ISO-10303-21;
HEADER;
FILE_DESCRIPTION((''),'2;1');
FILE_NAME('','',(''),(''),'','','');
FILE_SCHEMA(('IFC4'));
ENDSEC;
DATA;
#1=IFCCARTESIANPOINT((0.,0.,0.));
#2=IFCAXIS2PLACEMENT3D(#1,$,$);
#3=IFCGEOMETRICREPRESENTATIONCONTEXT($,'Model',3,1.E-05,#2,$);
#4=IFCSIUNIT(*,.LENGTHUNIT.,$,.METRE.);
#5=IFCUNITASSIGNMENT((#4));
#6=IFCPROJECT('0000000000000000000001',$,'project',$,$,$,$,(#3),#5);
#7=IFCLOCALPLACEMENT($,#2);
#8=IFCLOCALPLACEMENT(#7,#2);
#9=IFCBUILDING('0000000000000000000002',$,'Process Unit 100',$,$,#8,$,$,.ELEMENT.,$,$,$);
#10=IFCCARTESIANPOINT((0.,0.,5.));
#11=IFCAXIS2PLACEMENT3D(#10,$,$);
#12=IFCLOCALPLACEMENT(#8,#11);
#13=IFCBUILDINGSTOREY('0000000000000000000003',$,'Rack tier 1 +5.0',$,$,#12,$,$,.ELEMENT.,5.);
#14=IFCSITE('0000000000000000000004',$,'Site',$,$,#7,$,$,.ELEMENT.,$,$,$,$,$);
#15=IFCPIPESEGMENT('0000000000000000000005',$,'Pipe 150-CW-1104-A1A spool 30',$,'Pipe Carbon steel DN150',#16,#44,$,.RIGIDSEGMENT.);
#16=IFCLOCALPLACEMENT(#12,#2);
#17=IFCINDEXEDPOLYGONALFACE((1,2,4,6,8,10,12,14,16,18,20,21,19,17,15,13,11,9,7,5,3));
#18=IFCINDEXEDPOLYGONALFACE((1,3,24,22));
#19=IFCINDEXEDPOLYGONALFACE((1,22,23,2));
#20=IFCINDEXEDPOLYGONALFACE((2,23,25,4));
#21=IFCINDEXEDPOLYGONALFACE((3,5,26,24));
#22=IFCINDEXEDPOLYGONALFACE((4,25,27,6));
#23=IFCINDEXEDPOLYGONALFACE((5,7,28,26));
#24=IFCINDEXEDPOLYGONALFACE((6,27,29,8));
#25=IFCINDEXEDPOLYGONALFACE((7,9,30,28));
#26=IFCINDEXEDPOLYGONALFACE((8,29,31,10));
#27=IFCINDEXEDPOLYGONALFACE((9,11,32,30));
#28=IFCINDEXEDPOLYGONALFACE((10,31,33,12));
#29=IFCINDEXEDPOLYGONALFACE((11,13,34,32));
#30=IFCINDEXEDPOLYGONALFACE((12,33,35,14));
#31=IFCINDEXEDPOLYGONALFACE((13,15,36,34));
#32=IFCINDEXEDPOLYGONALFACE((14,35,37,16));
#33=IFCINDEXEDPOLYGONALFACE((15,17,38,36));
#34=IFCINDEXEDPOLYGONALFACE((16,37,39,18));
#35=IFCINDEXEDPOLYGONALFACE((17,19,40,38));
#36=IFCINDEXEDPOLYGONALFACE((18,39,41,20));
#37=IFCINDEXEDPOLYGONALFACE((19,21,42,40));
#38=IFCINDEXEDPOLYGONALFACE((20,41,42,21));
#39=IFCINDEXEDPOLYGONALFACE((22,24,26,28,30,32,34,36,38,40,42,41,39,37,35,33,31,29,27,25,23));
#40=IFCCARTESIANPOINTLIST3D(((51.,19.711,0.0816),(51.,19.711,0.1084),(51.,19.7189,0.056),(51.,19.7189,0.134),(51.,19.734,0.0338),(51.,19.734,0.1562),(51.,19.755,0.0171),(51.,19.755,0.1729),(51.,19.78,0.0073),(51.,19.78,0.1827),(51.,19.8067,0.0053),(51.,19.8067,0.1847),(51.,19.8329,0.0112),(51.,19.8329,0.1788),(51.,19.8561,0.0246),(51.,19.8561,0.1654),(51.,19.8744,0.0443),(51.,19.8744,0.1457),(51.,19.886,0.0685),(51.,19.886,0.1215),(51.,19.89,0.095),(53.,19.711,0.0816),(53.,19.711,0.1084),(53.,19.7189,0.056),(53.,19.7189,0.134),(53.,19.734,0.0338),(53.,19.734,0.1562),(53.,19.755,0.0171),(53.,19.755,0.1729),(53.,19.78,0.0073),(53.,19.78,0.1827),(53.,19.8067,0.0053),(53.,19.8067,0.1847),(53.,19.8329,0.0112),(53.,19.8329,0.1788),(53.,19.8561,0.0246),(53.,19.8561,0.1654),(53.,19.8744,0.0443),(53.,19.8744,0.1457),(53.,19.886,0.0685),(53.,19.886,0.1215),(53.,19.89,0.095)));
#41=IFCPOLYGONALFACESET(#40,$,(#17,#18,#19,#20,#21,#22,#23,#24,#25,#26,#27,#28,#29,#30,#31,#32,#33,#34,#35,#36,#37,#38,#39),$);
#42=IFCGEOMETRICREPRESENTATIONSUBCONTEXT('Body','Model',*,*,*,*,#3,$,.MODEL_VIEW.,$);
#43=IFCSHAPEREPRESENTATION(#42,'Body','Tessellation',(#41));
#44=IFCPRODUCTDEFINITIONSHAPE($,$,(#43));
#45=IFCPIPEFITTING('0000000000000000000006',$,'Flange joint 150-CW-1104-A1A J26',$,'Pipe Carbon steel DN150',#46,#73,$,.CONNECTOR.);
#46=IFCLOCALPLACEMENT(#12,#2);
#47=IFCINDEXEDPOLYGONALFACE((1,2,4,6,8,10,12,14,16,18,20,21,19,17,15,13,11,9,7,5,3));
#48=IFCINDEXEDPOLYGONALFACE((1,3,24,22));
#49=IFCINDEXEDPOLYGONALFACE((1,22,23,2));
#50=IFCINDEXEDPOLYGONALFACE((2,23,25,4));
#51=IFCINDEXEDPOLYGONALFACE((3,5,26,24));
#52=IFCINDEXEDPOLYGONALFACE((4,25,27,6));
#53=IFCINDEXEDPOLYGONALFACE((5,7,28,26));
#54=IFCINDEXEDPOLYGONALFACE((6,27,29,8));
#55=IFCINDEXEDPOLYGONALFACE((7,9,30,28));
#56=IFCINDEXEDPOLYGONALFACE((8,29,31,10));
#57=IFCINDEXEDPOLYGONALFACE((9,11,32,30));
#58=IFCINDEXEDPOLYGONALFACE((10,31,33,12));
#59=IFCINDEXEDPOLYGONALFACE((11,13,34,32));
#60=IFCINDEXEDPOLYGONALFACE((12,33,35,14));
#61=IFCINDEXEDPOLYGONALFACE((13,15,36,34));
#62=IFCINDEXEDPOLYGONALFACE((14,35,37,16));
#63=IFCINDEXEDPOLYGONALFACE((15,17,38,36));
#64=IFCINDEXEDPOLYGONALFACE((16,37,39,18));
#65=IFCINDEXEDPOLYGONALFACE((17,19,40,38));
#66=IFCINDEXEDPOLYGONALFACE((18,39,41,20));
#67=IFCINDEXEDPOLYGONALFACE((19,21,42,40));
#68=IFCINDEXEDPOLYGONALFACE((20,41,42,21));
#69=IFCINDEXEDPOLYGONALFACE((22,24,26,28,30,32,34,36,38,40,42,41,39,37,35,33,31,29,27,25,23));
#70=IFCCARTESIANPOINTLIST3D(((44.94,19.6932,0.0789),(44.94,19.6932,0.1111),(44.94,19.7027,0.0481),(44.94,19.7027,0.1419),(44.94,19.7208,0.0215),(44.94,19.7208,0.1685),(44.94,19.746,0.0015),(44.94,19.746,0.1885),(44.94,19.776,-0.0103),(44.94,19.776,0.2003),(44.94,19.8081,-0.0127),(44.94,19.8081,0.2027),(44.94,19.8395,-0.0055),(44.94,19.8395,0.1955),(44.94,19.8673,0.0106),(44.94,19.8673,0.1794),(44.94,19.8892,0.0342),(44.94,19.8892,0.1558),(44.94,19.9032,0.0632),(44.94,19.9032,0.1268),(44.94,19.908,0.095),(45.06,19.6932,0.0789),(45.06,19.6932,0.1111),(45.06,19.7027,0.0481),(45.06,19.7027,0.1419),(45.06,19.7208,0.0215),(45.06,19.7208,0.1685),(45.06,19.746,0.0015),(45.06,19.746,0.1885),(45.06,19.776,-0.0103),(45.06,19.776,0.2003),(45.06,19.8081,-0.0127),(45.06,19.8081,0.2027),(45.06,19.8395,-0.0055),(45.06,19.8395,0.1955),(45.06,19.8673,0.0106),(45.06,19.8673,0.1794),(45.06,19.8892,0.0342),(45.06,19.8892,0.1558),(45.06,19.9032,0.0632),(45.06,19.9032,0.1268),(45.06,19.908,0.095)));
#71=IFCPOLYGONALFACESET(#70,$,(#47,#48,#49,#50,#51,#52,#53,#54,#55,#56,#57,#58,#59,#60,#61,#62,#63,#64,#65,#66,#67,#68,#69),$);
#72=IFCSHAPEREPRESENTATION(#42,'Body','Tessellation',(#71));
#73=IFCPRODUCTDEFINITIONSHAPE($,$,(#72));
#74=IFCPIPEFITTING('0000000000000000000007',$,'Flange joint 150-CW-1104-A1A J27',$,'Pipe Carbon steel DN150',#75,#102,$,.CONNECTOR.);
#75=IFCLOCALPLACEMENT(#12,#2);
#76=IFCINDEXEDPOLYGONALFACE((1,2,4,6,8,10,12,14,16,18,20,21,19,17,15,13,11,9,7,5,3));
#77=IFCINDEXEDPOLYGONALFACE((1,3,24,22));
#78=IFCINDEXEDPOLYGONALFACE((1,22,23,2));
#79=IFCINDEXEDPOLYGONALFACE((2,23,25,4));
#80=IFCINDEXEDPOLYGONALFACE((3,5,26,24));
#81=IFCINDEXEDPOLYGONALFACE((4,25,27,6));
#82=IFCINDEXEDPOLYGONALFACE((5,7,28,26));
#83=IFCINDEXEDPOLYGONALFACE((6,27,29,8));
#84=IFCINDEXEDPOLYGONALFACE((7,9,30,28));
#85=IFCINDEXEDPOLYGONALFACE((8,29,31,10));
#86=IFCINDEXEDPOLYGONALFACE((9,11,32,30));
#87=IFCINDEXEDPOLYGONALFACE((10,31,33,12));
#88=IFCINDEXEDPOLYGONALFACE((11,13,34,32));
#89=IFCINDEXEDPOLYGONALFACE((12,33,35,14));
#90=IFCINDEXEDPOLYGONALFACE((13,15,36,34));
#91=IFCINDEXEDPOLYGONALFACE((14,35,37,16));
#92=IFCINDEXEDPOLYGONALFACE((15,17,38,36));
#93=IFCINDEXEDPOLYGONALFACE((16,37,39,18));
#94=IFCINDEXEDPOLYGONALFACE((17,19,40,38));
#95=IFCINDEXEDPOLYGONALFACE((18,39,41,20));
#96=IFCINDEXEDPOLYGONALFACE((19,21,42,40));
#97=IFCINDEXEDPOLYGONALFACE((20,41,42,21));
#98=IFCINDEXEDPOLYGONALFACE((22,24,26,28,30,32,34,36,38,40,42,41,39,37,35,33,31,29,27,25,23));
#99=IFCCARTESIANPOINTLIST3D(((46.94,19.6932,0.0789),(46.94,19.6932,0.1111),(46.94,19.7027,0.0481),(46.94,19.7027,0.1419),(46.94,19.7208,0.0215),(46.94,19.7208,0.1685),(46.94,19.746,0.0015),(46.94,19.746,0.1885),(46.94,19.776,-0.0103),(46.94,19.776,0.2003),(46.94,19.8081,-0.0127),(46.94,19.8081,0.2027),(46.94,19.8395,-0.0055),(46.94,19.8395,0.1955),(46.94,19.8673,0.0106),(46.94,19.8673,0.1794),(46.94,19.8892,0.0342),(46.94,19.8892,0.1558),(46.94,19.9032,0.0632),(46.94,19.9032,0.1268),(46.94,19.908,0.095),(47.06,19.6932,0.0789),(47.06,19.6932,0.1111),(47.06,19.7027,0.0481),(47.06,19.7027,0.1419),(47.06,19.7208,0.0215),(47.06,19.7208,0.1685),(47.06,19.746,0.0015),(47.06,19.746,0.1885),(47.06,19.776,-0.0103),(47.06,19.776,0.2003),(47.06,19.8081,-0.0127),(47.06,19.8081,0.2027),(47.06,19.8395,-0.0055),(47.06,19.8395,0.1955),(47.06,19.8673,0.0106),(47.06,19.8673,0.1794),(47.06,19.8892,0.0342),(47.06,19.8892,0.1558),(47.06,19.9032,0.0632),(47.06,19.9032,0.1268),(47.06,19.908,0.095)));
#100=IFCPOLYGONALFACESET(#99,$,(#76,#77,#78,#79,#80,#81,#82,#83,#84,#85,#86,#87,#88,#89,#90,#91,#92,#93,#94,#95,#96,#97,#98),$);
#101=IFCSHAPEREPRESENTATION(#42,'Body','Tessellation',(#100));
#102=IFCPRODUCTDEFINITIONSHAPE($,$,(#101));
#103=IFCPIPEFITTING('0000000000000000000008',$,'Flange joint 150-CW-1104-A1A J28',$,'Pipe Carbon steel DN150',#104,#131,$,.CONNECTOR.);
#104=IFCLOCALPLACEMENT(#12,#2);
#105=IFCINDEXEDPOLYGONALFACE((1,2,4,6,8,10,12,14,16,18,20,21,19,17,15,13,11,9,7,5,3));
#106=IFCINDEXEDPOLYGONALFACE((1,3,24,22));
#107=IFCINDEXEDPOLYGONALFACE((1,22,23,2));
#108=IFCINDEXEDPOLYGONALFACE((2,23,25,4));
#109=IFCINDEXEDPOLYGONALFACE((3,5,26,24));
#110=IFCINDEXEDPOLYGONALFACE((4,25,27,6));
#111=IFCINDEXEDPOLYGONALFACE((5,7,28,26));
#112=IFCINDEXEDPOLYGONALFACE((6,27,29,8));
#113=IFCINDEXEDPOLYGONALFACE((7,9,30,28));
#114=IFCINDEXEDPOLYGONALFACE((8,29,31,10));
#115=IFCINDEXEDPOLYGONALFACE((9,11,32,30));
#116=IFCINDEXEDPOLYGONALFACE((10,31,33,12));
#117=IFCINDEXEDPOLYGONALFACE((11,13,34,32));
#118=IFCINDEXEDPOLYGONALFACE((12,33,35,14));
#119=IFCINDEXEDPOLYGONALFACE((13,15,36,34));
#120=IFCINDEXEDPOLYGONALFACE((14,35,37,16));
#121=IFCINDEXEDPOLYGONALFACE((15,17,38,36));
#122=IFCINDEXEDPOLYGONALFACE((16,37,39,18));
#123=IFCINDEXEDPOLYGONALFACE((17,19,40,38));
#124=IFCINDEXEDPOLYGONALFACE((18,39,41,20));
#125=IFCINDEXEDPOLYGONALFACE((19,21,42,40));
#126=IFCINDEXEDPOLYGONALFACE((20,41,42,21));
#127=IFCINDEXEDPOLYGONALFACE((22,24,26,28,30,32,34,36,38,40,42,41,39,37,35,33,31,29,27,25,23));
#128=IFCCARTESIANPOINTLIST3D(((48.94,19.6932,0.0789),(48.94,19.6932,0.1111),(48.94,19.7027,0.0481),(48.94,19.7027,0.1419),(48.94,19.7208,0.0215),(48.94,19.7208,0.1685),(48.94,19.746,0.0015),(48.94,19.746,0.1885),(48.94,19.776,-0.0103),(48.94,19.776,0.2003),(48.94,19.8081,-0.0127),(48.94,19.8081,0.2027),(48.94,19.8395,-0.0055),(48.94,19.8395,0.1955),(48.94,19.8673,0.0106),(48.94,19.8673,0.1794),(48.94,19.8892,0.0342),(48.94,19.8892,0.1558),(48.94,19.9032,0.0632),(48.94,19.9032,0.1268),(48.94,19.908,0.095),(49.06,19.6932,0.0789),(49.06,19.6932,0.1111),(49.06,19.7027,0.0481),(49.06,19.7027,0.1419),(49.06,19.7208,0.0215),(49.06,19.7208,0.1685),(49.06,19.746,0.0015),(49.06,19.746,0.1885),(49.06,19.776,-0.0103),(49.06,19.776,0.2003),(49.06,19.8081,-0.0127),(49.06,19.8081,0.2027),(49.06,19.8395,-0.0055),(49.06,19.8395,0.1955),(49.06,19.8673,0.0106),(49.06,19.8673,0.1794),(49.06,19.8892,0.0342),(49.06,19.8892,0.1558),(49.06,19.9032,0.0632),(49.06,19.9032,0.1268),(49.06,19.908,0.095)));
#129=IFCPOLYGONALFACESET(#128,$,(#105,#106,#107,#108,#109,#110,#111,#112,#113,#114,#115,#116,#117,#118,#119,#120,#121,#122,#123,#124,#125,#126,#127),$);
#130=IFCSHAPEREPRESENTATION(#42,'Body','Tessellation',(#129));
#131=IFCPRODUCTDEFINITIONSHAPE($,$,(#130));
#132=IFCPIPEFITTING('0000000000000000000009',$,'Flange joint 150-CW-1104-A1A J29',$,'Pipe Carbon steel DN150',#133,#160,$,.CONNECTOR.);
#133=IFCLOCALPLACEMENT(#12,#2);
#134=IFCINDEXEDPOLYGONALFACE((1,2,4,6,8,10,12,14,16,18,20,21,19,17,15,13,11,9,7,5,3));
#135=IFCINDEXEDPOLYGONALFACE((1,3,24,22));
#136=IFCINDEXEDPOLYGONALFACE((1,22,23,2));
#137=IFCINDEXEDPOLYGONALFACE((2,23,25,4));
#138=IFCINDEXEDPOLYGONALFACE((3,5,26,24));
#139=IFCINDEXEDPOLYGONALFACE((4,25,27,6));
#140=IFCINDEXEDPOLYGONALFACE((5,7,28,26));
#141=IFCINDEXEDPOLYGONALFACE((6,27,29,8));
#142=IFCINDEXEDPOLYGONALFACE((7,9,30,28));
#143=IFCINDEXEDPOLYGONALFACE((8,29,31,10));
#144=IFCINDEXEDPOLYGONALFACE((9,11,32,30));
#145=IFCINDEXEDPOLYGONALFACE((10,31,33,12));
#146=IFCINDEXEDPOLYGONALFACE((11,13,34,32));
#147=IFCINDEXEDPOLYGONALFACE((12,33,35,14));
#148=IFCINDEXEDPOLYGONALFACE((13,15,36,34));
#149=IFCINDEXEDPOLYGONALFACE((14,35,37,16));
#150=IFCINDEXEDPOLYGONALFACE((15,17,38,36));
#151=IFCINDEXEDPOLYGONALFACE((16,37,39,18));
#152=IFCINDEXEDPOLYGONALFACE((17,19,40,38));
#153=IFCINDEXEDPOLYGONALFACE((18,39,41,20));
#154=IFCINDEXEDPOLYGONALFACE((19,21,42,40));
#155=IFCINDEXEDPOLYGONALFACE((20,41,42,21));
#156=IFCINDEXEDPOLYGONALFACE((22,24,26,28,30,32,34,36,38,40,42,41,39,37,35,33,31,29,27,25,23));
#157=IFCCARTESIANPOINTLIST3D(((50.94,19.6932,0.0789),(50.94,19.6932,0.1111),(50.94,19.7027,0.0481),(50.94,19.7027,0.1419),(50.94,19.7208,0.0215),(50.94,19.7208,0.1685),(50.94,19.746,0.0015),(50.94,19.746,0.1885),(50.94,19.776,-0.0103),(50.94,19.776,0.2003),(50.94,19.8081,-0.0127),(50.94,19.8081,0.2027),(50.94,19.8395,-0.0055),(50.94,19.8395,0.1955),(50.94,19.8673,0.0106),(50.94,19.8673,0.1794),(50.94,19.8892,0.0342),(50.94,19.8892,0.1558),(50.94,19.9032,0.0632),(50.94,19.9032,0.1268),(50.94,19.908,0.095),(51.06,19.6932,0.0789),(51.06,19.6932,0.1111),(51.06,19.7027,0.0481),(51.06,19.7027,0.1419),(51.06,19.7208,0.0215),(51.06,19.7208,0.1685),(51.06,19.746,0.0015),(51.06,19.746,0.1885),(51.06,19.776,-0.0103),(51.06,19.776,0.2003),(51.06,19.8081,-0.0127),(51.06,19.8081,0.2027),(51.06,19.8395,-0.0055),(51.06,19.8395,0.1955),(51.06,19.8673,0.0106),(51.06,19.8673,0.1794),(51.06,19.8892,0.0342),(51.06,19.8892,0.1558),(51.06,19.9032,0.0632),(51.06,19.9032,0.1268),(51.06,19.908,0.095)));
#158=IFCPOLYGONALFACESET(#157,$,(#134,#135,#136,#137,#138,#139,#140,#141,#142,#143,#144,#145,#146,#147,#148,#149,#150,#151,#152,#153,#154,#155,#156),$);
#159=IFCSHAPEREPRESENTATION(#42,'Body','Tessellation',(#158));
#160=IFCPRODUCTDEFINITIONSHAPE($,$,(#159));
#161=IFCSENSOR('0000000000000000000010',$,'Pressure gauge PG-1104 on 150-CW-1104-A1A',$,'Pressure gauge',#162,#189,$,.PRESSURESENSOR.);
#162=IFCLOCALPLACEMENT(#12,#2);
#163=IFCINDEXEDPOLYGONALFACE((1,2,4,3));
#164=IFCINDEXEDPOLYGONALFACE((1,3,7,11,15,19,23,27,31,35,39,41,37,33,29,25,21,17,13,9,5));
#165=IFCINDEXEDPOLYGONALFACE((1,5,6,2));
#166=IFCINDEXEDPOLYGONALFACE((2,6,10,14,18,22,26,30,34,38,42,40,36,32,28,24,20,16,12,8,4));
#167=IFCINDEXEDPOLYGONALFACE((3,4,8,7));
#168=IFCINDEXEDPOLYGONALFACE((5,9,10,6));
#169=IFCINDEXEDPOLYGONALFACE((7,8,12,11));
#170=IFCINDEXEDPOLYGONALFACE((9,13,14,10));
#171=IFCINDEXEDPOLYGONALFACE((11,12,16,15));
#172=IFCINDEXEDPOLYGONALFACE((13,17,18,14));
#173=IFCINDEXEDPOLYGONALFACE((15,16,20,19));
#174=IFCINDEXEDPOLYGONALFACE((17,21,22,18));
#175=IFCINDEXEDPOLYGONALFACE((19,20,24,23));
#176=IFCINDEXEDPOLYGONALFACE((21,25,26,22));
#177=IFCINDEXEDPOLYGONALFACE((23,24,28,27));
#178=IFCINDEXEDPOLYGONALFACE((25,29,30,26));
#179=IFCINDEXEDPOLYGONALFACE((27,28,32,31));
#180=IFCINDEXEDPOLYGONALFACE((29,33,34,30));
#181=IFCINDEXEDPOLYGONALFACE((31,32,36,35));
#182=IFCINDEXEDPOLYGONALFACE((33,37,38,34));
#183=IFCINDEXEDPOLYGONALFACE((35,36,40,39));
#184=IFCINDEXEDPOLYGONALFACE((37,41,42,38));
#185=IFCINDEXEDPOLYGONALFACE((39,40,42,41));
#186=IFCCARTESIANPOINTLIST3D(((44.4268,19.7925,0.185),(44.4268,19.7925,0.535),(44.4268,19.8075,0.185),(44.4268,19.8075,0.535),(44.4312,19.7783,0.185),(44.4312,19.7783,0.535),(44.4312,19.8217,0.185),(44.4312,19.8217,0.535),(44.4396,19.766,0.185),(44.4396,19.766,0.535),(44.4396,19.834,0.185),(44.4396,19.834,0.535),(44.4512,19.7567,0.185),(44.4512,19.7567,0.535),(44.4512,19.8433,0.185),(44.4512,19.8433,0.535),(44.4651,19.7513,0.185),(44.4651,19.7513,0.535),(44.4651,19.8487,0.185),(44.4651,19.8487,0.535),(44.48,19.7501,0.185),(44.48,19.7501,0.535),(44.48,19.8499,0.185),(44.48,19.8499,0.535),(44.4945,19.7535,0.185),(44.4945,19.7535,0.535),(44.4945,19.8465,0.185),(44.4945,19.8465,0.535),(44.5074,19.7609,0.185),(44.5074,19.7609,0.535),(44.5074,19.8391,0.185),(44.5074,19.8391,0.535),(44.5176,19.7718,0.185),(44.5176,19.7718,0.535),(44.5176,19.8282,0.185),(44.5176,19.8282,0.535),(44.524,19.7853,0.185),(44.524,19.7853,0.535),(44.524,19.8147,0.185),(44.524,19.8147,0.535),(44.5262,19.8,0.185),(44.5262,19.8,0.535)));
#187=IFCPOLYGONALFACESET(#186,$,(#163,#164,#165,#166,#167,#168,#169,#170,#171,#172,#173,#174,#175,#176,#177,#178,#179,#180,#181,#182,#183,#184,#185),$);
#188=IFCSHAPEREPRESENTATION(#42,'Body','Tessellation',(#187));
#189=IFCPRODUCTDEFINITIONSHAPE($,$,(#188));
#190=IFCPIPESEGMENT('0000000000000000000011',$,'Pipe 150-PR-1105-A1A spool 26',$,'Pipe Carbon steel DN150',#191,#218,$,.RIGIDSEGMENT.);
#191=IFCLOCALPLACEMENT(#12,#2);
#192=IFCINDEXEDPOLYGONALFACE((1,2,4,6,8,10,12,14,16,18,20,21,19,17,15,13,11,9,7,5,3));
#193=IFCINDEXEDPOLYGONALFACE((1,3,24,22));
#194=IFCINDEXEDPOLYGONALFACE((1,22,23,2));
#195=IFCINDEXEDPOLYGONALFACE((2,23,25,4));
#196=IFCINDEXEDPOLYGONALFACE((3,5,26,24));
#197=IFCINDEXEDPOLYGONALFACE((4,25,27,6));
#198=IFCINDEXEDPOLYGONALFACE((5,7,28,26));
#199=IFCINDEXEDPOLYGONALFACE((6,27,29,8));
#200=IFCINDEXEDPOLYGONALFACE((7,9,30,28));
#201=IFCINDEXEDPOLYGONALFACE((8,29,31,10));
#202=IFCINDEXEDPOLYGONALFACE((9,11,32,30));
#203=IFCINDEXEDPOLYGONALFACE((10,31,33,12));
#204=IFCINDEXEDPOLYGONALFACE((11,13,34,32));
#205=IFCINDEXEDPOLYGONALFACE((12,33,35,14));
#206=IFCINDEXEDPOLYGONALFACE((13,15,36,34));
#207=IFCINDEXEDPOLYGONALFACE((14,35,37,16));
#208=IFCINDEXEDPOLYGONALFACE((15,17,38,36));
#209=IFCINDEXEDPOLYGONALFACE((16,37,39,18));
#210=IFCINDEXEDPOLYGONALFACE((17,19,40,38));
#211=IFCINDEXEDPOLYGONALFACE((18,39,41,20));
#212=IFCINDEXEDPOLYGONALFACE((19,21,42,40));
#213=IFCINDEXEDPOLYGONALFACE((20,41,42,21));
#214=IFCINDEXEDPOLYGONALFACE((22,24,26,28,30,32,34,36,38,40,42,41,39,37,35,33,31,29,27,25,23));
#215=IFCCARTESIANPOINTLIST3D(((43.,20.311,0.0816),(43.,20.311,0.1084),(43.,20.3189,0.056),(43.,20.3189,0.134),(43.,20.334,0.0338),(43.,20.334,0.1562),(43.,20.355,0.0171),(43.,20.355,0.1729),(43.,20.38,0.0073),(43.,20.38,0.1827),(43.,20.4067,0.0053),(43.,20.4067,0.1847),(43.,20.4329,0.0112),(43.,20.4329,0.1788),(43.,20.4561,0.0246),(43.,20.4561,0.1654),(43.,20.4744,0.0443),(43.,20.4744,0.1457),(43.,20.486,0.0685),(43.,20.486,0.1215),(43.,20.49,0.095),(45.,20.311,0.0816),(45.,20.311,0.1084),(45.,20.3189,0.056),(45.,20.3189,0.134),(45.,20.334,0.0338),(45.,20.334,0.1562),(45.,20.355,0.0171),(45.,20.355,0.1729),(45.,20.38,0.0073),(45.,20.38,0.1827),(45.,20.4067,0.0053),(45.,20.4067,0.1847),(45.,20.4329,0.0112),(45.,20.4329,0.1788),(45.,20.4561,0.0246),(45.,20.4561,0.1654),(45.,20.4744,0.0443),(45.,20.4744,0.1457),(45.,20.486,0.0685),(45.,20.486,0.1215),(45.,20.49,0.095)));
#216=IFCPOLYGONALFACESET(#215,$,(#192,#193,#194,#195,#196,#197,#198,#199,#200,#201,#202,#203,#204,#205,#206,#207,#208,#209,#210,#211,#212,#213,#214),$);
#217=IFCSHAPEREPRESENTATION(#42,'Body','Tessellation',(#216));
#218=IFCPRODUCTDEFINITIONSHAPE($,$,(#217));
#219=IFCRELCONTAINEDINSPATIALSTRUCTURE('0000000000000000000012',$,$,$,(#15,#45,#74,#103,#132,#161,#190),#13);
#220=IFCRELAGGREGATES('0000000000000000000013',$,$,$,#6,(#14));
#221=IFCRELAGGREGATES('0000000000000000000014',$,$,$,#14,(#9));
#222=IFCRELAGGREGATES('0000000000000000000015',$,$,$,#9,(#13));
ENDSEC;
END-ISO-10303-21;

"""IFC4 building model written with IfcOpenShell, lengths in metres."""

from ifc_helpers import new_model, si_unit, frame, origin, place, context, subcontext, project, spatial, circle, extrude, element, save


model = new_model("IFC4")

# Units and contexts
model_context = context("Model", 3, precision=1e-05, world=origin())
body_context = subcontext(model_context, "Body", "Model", "MODEL_VIEW")
ifc_project = project(units=[si_unit("LENGTHUNIT", "METRE")], contexts=[model_context])

# Site, building, storey
site_placement = place(None, origin())
site = spatial("IfcSite", under=ifc_project, at=site_placement, Name="Site", CompositionType="ELEMENT")
building_placement = place(site_placement, origin())
building = spatial("IfcBuilding", under=site, at=building_placement, Name="Process Unit 100", CompositionType="ELEMENT")
storey_placement = place(building_placement, frame((0.0, 0.0, 5.0)))
storey = spatial("IfcBuildingStorey", under=building, at=storey_placement, Name="Rack tier 1 +5.0", CompositionType="ELEMENT", Elevation=5.0)

# Pipe segment
for number, where, z_axis, x_axis, name in (
    (1, (51.0, 19.8, 0.095), (1.0, 0.0, 0.0), (0.0, 1.0, 0.0), "Pipe 150-CW-1104-A1A spool 30"),
):
    element("IfcPipeSegment", number, at=place(storey_placement, frame(where, z_axis=z_axis, x_axis=x_axis)), inside=storey, Name=name, ObjectType="Pipe Carbon steel DN150", PredefinedType="RIGIDSEGMENT", context=body_context, shape_type="SweptSolid", body=[
        extrude(circle(Radius=0.09), origin(), (0.0, 0.0, 1.0), 2.0),
    ])

# Pipe fittings
for number, where, z_axis, x_axis, name in (
    (2, (44.94, 19.8, 0.095), (1.0, 0.0, 0.0), (0.0, 1.0, 0.0), "Flange joint 150-CW-1104-A1A J26"),
    (3, (46.94, 19.8, 0.095), (1.0, 0.0, 0.0), (0.0, 1.0, 0.0), "Flange joint 150-CW-1104-A1A J27"),
    (4, (48.94, 19.8, 0.095), (1.0, 0.0, 0.0), (0.0, 1.0, 0.0), "Flange joint 150-CW-1104-A1A J28"),
    (5, (50.94, 19.8, 0.095), (1.0, 0.0, 0.0), (0.0, 1.0, 0.0), "Flange joint 150-CW-1104-A1A J29"),
):
    element("IfcPipeFitting", number, at=place(storey_placement, frame(where, z_axis=z_axis, x_axis=x_axis)), inside=storey, Name=name, ObjectType="Pipe Carbon steel DN150", PredefinedType="CONNECTOR", context=body_context, shape_type="SweptSolid", body=[
        extrude(circle(Radius=0.108), origin(), (0.0, 0.0, 1.0), 0.12),
    ])

# Sensor
sensor_1_placement = place(storey_placement, frame((44.4763, 19.8, 0.185), z_axis=(0.0, 0.0, 1.0), x_axis=(1.0, 0.0, 0.0)))
element("IfcSensor", 6, at=sensor_1_placement, inside=storey, Name="Pressure gauge PG-1104 on 150-CW-1104-A1A", ObjectType="Pressure gauge", PredefinedType="PRESSURESENSOR", context=body_context, shape_type="SweptSolid", body=[
    extrude(circle(Radius=0.05), origin(), (0.0, 0.0, 1.0), 0.35),
])

# Pipe segment
for number, where, z_axis, x_axis, name in (
    (7, (43.0, 20.4, 0.095), (1.0, 0.0, 0.0), (0.0, 1.0, 0.0), "Pipe 150-PR-1105-A1A spool 26"),
):
    element("IfcPipeSegment", number, at=place(storey_placement, frame(where, z_axis=z_axis, x_axis=x_axis)), inside=storey, Name=name, ObjectType="Pipe Carbon steel DN150", PredefinedType="RIGIDSEGMENT", context=body_context, shape_type="SweptSolid", body=[
        extrude(circle(Radius=0.09), origin(), (0.0, 0.0, 1.0), 2.0),
    ])

save(model, "model.ifc")
